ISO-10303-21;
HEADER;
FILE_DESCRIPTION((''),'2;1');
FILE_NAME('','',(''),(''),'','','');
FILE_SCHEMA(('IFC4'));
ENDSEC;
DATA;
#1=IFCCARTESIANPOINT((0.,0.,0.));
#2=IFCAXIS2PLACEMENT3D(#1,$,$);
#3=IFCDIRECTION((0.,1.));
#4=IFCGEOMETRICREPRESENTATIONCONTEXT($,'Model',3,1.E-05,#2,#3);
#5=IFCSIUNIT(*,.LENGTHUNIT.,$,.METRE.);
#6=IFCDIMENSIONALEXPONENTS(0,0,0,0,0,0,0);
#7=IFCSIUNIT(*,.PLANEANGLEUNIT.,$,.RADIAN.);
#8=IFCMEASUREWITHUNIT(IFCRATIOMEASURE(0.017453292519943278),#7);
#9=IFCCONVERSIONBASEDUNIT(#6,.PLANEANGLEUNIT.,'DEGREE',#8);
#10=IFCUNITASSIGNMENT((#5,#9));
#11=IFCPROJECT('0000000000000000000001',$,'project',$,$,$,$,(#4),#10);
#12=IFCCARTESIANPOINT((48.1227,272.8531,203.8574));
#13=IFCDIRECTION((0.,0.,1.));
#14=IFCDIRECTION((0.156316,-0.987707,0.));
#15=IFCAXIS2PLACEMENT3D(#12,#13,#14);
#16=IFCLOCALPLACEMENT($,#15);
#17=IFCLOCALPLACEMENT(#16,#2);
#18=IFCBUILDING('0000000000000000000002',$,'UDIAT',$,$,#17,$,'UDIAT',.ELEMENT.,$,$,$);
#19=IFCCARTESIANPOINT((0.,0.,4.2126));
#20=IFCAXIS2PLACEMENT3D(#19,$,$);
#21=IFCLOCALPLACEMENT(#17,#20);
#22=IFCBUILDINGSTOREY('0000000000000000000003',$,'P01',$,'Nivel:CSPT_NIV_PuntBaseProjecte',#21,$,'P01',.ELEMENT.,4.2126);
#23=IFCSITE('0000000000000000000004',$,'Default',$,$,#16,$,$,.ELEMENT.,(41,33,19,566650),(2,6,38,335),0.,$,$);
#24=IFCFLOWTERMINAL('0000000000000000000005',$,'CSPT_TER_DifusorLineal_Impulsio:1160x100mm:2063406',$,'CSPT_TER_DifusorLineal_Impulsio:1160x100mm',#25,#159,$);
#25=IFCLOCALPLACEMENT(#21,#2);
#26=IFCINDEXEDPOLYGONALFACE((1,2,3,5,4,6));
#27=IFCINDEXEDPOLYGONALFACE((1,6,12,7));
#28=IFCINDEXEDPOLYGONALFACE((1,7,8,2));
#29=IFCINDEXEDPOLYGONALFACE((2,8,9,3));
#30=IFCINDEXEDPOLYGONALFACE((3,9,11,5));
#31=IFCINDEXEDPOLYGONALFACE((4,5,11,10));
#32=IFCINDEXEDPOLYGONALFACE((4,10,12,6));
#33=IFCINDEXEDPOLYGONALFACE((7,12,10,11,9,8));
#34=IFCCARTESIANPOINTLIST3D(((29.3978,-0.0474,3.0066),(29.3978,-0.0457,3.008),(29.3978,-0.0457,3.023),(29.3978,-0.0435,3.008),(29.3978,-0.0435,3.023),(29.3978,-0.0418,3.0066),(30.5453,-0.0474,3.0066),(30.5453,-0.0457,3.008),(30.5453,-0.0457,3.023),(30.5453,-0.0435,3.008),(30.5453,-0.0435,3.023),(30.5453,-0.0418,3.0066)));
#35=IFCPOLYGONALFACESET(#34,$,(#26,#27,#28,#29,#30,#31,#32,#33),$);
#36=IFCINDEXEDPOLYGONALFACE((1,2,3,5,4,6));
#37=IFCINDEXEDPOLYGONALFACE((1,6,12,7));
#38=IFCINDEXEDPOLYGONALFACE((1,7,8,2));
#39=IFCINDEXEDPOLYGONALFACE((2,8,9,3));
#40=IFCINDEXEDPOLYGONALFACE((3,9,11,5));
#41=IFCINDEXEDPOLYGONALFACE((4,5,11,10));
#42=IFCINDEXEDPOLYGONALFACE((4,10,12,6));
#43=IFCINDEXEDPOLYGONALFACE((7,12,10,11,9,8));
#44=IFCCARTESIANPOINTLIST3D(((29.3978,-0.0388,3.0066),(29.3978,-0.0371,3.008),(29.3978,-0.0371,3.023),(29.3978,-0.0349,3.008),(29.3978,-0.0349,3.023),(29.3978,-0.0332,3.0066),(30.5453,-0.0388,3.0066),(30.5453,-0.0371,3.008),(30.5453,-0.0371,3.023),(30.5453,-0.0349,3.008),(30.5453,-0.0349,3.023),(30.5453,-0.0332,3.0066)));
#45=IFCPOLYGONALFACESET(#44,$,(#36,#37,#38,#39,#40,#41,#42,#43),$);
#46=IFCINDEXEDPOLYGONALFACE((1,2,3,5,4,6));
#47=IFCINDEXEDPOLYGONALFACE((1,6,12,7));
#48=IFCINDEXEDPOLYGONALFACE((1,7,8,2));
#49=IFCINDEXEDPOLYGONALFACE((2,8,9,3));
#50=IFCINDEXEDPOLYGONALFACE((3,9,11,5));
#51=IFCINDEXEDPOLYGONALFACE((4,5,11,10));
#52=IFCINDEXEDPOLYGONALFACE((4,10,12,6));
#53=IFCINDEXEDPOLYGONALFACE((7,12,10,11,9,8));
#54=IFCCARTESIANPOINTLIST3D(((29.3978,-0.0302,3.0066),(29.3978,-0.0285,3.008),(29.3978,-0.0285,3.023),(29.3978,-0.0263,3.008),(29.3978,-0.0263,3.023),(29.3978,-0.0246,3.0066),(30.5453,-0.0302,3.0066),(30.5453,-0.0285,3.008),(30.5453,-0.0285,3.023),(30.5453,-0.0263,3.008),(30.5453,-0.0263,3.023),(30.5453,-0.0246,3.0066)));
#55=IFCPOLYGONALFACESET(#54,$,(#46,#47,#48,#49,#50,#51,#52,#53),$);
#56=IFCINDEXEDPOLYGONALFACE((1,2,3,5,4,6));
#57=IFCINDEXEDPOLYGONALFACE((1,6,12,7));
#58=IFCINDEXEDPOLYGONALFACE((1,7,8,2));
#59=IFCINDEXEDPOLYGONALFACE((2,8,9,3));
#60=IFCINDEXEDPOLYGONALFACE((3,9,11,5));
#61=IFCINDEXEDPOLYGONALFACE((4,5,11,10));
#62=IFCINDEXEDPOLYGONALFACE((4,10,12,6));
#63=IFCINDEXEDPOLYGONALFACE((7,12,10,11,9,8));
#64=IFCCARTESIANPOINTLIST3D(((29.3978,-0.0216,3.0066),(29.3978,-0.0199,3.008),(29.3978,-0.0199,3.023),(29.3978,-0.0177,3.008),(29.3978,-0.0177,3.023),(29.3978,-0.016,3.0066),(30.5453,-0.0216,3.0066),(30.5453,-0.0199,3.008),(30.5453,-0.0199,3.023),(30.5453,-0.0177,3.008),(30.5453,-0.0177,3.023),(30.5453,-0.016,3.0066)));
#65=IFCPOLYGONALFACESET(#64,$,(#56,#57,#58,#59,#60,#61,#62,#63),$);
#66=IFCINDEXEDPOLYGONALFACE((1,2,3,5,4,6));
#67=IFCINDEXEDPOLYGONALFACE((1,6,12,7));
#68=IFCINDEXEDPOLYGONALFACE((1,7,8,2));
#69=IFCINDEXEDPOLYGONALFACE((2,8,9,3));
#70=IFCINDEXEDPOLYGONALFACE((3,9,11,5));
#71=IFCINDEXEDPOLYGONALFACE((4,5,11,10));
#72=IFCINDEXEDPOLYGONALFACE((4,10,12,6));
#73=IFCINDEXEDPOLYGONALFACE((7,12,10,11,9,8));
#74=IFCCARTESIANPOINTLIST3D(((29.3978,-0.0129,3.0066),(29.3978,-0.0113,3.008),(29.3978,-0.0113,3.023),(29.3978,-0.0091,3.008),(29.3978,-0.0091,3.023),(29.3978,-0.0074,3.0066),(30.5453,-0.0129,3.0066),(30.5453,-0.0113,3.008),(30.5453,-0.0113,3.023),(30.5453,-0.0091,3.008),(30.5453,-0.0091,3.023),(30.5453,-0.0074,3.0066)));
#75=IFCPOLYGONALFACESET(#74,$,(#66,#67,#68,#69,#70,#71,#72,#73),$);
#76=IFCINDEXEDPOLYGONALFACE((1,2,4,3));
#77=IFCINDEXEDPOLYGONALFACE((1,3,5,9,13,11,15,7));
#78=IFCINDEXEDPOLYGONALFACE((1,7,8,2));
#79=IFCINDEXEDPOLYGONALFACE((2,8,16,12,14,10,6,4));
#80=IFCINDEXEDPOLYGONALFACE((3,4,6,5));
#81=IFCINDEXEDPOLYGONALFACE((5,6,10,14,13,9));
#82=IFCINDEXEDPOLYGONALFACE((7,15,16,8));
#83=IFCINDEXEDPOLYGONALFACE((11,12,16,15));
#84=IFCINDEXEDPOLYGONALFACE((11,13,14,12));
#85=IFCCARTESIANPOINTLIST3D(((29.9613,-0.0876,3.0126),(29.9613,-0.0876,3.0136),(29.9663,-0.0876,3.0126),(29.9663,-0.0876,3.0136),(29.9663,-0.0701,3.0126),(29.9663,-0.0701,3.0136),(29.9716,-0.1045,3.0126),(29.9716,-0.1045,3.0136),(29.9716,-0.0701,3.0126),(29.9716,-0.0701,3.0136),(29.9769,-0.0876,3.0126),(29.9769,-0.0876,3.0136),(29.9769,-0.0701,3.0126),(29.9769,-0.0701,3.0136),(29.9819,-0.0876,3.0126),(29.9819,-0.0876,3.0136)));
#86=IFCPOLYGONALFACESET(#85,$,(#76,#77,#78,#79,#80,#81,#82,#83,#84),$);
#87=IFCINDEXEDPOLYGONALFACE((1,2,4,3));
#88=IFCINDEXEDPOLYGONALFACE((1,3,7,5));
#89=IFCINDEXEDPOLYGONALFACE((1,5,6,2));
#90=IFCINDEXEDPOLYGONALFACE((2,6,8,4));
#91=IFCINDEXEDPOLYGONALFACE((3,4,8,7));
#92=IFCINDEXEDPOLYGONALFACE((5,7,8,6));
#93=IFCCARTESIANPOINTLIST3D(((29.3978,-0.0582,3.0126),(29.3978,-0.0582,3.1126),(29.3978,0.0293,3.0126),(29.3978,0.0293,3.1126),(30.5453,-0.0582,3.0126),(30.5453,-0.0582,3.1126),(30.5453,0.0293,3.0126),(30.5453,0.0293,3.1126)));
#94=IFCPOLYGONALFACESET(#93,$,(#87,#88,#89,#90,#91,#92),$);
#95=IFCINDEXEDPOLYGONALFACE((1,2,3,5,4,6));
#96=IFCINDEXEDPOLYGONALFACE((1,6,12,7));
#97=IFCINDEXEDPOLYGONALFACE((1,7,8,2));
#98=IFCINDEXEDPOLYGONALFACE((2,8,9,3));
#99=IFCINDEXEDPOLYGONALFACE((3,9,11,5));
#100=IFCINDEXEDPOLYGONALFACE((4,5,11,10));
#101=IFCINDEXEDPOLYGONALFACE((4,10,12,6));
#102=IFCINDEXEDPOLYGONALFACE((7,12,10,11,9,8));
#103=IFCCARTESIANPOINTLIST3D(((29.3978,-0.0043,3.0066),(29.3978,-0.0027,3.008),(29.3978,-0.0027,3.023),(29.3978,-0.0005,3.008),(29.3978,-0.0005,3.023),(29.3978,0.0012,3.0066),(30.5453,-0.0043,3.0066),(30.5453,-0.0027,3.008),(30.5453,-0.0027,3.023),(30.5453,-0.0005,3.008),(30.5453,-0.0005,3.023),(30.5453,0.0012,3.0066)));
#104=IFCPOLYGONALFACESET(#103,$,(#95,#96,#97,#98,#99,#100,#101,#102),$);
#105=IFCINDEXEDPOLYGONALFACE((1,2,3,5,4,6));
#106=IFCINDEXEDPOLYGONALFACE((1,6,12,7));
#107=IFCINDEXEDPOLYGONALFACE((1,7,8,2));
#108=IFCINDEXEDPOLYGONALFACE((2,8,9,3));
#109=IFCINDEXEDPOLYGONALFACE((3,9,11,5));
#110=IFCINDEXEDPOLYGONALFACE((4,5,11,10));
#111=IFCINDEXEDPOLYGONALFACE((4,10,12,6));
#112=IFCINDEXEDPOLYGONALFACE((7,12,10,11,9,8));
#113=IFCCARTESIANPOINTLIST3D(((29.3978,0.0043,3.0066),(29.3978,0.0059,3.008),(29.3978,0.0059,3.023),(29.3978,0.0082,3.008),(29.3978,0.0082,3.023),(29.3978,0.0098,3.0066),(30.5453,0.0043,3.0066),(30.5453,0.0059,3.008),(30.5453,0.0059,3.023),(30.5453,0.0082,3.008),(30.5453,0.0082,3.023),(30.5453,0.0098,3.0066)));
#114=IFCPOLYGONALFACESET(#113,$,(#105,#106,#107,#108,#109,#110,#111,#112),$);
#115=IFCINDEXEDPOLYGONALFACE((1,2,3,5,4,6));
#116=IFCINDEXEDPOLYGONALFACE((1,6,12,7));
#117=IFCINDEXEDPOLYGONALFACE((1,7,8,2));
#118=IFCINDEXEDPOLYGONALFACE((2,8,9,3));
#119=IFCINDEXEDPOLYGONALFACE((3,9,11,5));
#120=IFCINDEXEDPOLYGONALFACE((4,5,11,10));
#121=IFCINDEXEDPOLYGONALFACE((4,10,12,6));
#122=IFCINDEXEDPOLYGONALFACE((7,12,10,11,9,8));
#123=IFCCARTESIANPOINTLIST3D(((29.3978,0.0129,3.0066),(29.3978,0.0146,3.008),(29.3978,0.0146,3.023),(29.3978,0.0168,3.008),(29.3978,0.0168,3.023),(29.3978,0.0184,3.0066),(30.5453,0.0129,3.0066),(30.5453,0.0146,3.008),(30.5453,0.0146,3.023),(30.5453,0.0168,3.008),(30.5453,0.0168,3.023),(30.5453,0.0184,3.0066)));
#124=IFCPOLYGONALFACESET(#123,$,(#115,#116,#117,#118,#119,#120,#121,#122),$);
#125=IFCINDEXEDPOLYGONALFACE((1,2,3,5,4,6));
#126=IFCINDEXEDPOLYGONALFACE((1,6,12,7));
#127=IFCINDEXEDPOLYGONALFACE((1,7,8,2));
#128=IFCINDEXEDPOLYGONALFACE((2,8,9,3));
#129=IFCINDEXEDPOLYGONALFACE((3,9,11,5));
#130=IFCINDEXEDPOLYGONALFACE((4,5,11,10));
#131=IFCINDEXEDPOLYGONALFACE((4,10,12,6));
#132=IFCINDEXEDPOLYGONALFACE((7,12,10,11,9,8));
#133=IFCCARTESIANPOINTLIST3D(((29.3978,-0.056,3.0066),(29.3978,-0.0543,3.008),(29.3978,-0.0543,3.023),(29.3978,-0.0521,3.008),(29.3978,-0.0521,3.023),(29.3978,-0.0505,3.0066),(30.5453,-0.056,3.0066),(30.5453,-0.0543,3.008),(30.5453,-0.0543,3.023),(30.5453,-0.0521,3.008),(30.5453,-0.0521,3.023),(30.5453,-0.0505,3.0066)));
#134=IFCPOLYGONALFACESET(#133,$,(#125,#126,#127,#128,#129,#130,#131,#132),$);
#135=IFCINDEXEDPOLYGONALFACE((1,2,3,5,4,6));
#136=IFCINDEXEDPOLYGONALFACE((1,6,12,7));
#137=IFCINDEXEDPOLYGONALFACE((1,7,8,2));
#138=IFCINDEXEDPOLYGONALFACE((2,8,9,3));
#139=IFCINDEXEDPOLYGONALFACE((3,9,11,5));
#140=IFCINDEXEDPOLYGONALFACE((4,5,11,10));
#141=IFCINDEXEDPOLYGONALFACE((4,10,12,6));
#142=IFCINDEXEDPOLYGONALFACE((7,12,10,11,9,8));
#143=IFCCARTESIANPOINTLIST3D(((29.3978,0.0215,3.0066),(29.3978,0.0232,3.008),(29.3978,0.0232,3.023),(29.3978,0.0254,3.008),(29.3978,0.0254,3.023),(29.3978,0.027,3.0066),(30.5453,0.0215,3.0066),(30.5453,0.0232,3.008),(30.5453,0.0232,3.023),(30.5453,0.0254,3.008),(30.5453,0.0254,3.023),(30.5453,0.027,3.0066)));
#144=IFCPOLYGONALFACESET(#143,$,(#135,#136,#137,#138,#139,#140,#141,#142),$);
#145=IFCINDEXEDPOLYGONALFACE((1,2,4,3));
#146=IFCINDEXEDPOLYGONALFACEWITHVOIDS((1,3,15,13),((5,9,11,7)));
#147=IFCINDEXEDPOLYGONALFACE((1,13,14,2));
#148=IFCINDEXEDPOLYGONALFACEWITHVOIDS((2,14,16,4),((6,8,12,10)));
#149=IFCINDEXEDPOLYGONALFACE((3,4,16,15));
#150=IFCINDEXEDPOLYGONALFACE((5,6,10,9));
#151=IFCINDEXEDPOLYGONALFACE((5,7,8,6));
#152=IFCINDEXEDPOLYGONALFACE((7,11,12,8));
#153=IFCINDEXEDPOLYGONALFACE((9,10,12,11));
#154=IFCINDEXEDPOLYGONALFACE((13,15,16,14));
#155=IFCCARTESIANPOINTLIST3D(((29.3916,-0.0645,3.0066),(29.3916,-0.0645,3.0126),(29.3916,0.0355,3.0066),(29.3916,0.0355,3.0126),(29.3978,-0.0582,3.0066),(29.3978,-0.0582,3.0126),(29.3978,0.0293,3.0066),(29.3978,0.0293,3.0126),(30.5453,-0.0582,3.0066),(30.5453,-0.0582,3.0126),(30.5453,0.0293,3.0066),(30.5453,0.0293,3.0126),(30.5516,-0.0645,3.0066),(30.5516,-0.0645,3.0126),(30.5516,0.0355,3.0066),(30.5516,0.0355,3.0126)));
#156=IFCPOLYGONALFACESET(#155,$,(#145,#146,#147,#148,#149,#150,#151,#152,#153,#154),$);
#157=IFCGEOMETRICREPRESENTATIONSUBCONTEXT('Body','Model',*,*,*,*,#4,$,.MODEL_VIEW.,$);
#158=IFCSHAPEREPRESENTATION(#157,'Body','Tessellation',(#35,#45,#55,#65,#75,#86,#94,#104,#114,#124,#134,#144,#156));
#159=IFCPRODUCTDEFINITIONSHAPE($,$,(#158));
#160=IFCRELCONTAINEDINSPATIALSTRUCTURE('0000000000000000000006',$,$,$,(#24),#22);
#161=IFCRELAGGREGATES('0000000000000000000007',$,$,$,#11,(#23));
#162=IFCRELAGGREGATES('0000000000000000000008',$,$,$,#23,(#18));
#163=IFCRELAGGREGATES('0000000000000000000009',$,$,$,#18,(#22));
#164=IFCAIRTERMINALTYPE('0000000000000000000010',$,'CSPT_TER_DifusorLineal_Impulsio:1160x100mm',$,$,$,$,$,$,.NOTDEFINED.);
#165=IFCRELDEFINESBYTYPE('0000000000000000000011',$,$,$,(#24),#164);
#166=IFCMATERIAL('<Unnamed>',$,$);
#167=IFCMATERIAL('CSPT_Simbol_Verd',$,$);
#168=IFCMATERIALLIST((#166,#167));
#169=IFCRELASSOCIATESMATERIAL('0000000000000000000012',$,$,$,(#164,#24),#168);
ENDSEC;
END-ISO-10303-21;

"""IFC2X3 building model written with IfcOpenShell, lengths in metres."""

from ifc_helpers import new_model, entity, si_unit, converted_unit, direction, frame, origin, origin_2d_with_axis, place, context, subcontext, project, spatial, polyline, rectangle, outline, extrude, source, transform, mapped, material, material_list, type_object, type_shapes, element, save


model = new_model("IFC2X3")

# Units and contexts
model_context = context("Model", 3, precision=1e-05, world=origin(), true_north=direction((0.0, 1.0)))
body_context = subcontext(model_context, "Body", "Model", "MODEL_VIEW")
ifc_project = project(units=[si_unit("LENGTHUNIT", "METRE"), converted_unit("PLANEANGLEUNIT", "DEGREE", entity("IfcRatioMeasure", 0.017453292519943278), si_unit("PLANEANGLEUNIT", "RADIAN"), dimensions=[0, 0, 0, 0, 0, 0, 0])], contexts=[model_context])

# Site, building, storey
site_placement = place(None, frame((48.1227, 272.8531, 203.8574), z_axis=(0.0, 0.0, 1.0), x_axis=(0.156316, -0.987707, 0.0)))
site = spatial("IfcSite", under=ifc_project, at=site_placement, Name="Default", CompositionType="ELEMENT", RefLatitude=(41, 33, 19, 566650), RefLongitude=(2, 6, 38, 335), RefElevation=0.0)
building_placement = place(site_placement, origin())
building = spatial("IfcBuilding", under=site, at=building_placement, Name="UDIAT", LongName="UDIAT", CompositionType="ELEMENT")
storey_placement = place(building_placement, frame((0.0, 0.0, 4.2126)))
storey = spatial("IfcBuildingStorey", under=building, at=storey_placement, Name="P01", ObjectType="Nivel:CSPT_NIV_PuntBaseProjecte", LongName="P01", CompositionType="ELEMENT", Elevation=4.2126)

# Shared definitions
ifc_material_1 = material(Name="<Unnamed>")

# Flow terminal
ifc_material_2 = material(Name="CSPT_Simbol_Verd")
ifc_material_list = material_list([ifc_material_1, ifc_material_2])
air_terminal_type = type_object("IfcAirTerminalType", Name="CSPT_TER_DifusorLineal_Impulsio:1160x100mm", PredefinedType="NOTDEFINED", material=ifc_material_list)
shared_shape_1 = source(origin(), body_context, "Body", "SweptSolid", [
    extrude(outline(polyline([(0.0037, 0.0028), (0.0059, 0.0028), (0.0016, 0.0063), (0.002, 0.0042), (-0.0074, -0.0074), (-0.0057, -0.0088), (0.0037, 0.0028)])), frame((-0.5737, 0.0301, -0.0001), z_axis=(1.0, 0.0, 0.0), x_axis=(0.0, -0.776119, -0.630587)), (0.0, 0.0, 1.0), 1.1475),
    extrude(outline(polyline([(0.0037, 0.0028), (0.0059, 0.0028), (0.0016, 0.0063), (0.002, 0.0042), (-0.0074, -0.0074), (-0.0057, -0.0088), (0.0037, 0.0028)])), frame((-0.5737, 0.0215, -0.0001), z_axis=(1.0, 0.0, 0.0), x_axis=(0.0, -0.776119, -0.630587)), (0.0, 0.0, 1.0), 1.1475),
    extrude(outline(polyline([(0.0037, 0.0028), (0.0059, 0.0028), (0.0016, 0.0063), (0.002, 0.0042), (-0.0074, -0.0074), (-0.0057, -0.0088), (0.0037, 0.0028)])), frame((-0.5737, 0.0129, -0.0001), z_axis=(1.0, 0.0, 0.0), x_axis=(0.0, -0.776119, -0.630587)), (0.0, 0.0, 1.0), 1.1475),
    extrude(outline(polyline([(0.0037, 0.0028), (0.0059, 0.0028), (0.0016, 0.0063), (0.002, 0.0042), (-0.0074, -0.0074), (-0.0057, -0.0088), (0.0037, 0.0028)])), frame((-0.5737, 0.0043, -0.0001), z_axis=(1.0, 0.0, 0.0), x_axis=(0.0, -0.776119, -0.630587)), (0.0, 0.0, 1.0), 1.1475),
    extrude(outline(polyline([(0.0037, 0.0028), (0.0059, 0.0028), (0.0016, 0.0063), (0.002, 0.0042), (-0.0074, -0.0074), (-0.0057, -0.0088), (0.0037, 0.0028)])), frame((-0.5737, -0.0043, -0.0001), z_axis=(1.0, 0.0, 0.0), x_axis=(0.0, -0.776119, -0.630587)), (0.0, 0.0, 1.0), 1.1475),
    extrude(outline(polyline([(0.0, -0.013), (0.0053, -0.013), (0.0053, 0.0045), (0.0103, 0.0045), (0.0, 0.0213), (-0.0103, 0.0045), (-0.0053, 0.0045), (-0.0053, -0.013), (0.0, -0.013)])), frame((0.0, 0.0687, 0.0)), (0.0, 0.0, 1.0), 0.001),
    extrude(rectangle(XDim=1.1475, YDim=0.0875, at=origin_2d_with_axis()), frame((0.0, 0.0, 0.0), z_axis=(0.0, 0.0, 1.0), x_axis=(-1.0, 0.0, 0.0)), (0.0, 0.0, 1.0), 0.1),
    extrude(outline(polyline([(0.0037, 0.0028), (0.0059, 0.0028), (0.0016, 0.0063), (0.002, 0.0042), (-0.0074, -0.0074), (-0.0057, -0.0088), (0.0037, 0.0028)])), frame((-0.5737, -0.0129, -0.0001), z_axis=(1.0, 0.0, 0.0), x_axis=(0.0, -0.776119, -0.630587)), (0.0, 0.0, 1.0), 1.1475),
    extrude(outline(polyline([(0.0037, 0.0028), (0.0059, 0.0028), (0.0016, 0.0063), (0.002, 0.0042), (-0.0074, -0.0074), (-0.0057, -0.0088), (0.0037, 0.0028)])), frame((-0.5737, -0.0215, -0.0001), z_axis=(1.0, 0.0, 0.0), x_axis=(0.0, -0.776119, -0.630587)), (0.0, 0.0, 1.0), 1.1475),
    extrude(outline(polyline([(0.0037, 0.0028), (0.0059, 0.0028), (0.0016, 0.0063), (0.002, 0.0042), (-0.0074, -0.0074), (-0.0057, -0.0088), (0.0037, 0.0028)])), frame((-0.5737, -0.0301, -0.0001), z_axis=(1.0, 0.0, 0.0), x_axis=(0.0, -0.776119, -0.630587)), (0.0, 0.0, 1.0), 1.1475),
    extrude(outline(polyline([(0.0037, 0.0028), (0.0059, 0.0028), (0.0016, 0.0063), (0.002, 0.0042), (-0.0074, -0.0074), (-0.0057, -0.0088), (0.0037, 0.0028)])), frame((-0.5737, 0.0388, -0.0001), z_axis=(1.0, 0.0, 0.0), x_axis=(0.0, -0.776119, -0.630587)), (0.0, 0.0, 1.0), 1.1475),
    extrude(outline(polyline([(0.0037, 0.0028), (0.0059, 0.0028), (0.0016, 0.0063), (0.002, 0.0042), (-0.0074, -0.0074), (-0.0057, -0.0088), (0.0037, 0.0028)])), frame((-0.5737, -0.0387, -0.0001), z_axis=(1.0, 0.0, 0.0), x_axis=(0.0, -0.776119, -0.630587)), (0.0, 0.0, 1.0), 1.1475),
    extrude(outline(polyline([(-0.58, -0.05), (0.58, -0.05), (0.58, 0.05), (-0.58, 0.05), (-0.58, -0.05)]), holes=[polyline([(-0.5738, -0.0438), (-0.5738, 0.0437), (0.5737, 0.0437), (0.5737, -0.0438), (-0.5738, -0.0438)])]), frame((0.0, 0.0, -0.006), z_axis=(0.0, 0.0, 1.0), x_axis=(-1.0, 0.0, 0.0)), (0.0, 0.0, 1.0), 0.006),
])
type_shapes(air_terminal_type, [shared_shape_1])
for number, where, z_axis, x_axis, name in (
    (1, (29.9716, -0.0145, 3.0126), (0.0, 0.0, 1.0), (-1.0, 0.0, 0.0), "CSPT_TER_DifusorLineal_Impulsio:1160x100mm:2063406"),
):
    element("IfcFlowTerminal", number, at=place(storey_placement, frame(where, z_axis=z_axis, x_axis=x_axis)), inside=storey, type_object=air_terminal_type, material=ifc_material_list, Name=name, ObjectType="CSPT_TER_DifusorLineal_Impulsio:1160x100mm", context=body_context, shape_type="MappedRepresentation", body=[
        mapped(shared_shape_1, transform((0.0, 0.0, 0.0), scale=1.0)),
    ])

save(model, "model.ifc")
